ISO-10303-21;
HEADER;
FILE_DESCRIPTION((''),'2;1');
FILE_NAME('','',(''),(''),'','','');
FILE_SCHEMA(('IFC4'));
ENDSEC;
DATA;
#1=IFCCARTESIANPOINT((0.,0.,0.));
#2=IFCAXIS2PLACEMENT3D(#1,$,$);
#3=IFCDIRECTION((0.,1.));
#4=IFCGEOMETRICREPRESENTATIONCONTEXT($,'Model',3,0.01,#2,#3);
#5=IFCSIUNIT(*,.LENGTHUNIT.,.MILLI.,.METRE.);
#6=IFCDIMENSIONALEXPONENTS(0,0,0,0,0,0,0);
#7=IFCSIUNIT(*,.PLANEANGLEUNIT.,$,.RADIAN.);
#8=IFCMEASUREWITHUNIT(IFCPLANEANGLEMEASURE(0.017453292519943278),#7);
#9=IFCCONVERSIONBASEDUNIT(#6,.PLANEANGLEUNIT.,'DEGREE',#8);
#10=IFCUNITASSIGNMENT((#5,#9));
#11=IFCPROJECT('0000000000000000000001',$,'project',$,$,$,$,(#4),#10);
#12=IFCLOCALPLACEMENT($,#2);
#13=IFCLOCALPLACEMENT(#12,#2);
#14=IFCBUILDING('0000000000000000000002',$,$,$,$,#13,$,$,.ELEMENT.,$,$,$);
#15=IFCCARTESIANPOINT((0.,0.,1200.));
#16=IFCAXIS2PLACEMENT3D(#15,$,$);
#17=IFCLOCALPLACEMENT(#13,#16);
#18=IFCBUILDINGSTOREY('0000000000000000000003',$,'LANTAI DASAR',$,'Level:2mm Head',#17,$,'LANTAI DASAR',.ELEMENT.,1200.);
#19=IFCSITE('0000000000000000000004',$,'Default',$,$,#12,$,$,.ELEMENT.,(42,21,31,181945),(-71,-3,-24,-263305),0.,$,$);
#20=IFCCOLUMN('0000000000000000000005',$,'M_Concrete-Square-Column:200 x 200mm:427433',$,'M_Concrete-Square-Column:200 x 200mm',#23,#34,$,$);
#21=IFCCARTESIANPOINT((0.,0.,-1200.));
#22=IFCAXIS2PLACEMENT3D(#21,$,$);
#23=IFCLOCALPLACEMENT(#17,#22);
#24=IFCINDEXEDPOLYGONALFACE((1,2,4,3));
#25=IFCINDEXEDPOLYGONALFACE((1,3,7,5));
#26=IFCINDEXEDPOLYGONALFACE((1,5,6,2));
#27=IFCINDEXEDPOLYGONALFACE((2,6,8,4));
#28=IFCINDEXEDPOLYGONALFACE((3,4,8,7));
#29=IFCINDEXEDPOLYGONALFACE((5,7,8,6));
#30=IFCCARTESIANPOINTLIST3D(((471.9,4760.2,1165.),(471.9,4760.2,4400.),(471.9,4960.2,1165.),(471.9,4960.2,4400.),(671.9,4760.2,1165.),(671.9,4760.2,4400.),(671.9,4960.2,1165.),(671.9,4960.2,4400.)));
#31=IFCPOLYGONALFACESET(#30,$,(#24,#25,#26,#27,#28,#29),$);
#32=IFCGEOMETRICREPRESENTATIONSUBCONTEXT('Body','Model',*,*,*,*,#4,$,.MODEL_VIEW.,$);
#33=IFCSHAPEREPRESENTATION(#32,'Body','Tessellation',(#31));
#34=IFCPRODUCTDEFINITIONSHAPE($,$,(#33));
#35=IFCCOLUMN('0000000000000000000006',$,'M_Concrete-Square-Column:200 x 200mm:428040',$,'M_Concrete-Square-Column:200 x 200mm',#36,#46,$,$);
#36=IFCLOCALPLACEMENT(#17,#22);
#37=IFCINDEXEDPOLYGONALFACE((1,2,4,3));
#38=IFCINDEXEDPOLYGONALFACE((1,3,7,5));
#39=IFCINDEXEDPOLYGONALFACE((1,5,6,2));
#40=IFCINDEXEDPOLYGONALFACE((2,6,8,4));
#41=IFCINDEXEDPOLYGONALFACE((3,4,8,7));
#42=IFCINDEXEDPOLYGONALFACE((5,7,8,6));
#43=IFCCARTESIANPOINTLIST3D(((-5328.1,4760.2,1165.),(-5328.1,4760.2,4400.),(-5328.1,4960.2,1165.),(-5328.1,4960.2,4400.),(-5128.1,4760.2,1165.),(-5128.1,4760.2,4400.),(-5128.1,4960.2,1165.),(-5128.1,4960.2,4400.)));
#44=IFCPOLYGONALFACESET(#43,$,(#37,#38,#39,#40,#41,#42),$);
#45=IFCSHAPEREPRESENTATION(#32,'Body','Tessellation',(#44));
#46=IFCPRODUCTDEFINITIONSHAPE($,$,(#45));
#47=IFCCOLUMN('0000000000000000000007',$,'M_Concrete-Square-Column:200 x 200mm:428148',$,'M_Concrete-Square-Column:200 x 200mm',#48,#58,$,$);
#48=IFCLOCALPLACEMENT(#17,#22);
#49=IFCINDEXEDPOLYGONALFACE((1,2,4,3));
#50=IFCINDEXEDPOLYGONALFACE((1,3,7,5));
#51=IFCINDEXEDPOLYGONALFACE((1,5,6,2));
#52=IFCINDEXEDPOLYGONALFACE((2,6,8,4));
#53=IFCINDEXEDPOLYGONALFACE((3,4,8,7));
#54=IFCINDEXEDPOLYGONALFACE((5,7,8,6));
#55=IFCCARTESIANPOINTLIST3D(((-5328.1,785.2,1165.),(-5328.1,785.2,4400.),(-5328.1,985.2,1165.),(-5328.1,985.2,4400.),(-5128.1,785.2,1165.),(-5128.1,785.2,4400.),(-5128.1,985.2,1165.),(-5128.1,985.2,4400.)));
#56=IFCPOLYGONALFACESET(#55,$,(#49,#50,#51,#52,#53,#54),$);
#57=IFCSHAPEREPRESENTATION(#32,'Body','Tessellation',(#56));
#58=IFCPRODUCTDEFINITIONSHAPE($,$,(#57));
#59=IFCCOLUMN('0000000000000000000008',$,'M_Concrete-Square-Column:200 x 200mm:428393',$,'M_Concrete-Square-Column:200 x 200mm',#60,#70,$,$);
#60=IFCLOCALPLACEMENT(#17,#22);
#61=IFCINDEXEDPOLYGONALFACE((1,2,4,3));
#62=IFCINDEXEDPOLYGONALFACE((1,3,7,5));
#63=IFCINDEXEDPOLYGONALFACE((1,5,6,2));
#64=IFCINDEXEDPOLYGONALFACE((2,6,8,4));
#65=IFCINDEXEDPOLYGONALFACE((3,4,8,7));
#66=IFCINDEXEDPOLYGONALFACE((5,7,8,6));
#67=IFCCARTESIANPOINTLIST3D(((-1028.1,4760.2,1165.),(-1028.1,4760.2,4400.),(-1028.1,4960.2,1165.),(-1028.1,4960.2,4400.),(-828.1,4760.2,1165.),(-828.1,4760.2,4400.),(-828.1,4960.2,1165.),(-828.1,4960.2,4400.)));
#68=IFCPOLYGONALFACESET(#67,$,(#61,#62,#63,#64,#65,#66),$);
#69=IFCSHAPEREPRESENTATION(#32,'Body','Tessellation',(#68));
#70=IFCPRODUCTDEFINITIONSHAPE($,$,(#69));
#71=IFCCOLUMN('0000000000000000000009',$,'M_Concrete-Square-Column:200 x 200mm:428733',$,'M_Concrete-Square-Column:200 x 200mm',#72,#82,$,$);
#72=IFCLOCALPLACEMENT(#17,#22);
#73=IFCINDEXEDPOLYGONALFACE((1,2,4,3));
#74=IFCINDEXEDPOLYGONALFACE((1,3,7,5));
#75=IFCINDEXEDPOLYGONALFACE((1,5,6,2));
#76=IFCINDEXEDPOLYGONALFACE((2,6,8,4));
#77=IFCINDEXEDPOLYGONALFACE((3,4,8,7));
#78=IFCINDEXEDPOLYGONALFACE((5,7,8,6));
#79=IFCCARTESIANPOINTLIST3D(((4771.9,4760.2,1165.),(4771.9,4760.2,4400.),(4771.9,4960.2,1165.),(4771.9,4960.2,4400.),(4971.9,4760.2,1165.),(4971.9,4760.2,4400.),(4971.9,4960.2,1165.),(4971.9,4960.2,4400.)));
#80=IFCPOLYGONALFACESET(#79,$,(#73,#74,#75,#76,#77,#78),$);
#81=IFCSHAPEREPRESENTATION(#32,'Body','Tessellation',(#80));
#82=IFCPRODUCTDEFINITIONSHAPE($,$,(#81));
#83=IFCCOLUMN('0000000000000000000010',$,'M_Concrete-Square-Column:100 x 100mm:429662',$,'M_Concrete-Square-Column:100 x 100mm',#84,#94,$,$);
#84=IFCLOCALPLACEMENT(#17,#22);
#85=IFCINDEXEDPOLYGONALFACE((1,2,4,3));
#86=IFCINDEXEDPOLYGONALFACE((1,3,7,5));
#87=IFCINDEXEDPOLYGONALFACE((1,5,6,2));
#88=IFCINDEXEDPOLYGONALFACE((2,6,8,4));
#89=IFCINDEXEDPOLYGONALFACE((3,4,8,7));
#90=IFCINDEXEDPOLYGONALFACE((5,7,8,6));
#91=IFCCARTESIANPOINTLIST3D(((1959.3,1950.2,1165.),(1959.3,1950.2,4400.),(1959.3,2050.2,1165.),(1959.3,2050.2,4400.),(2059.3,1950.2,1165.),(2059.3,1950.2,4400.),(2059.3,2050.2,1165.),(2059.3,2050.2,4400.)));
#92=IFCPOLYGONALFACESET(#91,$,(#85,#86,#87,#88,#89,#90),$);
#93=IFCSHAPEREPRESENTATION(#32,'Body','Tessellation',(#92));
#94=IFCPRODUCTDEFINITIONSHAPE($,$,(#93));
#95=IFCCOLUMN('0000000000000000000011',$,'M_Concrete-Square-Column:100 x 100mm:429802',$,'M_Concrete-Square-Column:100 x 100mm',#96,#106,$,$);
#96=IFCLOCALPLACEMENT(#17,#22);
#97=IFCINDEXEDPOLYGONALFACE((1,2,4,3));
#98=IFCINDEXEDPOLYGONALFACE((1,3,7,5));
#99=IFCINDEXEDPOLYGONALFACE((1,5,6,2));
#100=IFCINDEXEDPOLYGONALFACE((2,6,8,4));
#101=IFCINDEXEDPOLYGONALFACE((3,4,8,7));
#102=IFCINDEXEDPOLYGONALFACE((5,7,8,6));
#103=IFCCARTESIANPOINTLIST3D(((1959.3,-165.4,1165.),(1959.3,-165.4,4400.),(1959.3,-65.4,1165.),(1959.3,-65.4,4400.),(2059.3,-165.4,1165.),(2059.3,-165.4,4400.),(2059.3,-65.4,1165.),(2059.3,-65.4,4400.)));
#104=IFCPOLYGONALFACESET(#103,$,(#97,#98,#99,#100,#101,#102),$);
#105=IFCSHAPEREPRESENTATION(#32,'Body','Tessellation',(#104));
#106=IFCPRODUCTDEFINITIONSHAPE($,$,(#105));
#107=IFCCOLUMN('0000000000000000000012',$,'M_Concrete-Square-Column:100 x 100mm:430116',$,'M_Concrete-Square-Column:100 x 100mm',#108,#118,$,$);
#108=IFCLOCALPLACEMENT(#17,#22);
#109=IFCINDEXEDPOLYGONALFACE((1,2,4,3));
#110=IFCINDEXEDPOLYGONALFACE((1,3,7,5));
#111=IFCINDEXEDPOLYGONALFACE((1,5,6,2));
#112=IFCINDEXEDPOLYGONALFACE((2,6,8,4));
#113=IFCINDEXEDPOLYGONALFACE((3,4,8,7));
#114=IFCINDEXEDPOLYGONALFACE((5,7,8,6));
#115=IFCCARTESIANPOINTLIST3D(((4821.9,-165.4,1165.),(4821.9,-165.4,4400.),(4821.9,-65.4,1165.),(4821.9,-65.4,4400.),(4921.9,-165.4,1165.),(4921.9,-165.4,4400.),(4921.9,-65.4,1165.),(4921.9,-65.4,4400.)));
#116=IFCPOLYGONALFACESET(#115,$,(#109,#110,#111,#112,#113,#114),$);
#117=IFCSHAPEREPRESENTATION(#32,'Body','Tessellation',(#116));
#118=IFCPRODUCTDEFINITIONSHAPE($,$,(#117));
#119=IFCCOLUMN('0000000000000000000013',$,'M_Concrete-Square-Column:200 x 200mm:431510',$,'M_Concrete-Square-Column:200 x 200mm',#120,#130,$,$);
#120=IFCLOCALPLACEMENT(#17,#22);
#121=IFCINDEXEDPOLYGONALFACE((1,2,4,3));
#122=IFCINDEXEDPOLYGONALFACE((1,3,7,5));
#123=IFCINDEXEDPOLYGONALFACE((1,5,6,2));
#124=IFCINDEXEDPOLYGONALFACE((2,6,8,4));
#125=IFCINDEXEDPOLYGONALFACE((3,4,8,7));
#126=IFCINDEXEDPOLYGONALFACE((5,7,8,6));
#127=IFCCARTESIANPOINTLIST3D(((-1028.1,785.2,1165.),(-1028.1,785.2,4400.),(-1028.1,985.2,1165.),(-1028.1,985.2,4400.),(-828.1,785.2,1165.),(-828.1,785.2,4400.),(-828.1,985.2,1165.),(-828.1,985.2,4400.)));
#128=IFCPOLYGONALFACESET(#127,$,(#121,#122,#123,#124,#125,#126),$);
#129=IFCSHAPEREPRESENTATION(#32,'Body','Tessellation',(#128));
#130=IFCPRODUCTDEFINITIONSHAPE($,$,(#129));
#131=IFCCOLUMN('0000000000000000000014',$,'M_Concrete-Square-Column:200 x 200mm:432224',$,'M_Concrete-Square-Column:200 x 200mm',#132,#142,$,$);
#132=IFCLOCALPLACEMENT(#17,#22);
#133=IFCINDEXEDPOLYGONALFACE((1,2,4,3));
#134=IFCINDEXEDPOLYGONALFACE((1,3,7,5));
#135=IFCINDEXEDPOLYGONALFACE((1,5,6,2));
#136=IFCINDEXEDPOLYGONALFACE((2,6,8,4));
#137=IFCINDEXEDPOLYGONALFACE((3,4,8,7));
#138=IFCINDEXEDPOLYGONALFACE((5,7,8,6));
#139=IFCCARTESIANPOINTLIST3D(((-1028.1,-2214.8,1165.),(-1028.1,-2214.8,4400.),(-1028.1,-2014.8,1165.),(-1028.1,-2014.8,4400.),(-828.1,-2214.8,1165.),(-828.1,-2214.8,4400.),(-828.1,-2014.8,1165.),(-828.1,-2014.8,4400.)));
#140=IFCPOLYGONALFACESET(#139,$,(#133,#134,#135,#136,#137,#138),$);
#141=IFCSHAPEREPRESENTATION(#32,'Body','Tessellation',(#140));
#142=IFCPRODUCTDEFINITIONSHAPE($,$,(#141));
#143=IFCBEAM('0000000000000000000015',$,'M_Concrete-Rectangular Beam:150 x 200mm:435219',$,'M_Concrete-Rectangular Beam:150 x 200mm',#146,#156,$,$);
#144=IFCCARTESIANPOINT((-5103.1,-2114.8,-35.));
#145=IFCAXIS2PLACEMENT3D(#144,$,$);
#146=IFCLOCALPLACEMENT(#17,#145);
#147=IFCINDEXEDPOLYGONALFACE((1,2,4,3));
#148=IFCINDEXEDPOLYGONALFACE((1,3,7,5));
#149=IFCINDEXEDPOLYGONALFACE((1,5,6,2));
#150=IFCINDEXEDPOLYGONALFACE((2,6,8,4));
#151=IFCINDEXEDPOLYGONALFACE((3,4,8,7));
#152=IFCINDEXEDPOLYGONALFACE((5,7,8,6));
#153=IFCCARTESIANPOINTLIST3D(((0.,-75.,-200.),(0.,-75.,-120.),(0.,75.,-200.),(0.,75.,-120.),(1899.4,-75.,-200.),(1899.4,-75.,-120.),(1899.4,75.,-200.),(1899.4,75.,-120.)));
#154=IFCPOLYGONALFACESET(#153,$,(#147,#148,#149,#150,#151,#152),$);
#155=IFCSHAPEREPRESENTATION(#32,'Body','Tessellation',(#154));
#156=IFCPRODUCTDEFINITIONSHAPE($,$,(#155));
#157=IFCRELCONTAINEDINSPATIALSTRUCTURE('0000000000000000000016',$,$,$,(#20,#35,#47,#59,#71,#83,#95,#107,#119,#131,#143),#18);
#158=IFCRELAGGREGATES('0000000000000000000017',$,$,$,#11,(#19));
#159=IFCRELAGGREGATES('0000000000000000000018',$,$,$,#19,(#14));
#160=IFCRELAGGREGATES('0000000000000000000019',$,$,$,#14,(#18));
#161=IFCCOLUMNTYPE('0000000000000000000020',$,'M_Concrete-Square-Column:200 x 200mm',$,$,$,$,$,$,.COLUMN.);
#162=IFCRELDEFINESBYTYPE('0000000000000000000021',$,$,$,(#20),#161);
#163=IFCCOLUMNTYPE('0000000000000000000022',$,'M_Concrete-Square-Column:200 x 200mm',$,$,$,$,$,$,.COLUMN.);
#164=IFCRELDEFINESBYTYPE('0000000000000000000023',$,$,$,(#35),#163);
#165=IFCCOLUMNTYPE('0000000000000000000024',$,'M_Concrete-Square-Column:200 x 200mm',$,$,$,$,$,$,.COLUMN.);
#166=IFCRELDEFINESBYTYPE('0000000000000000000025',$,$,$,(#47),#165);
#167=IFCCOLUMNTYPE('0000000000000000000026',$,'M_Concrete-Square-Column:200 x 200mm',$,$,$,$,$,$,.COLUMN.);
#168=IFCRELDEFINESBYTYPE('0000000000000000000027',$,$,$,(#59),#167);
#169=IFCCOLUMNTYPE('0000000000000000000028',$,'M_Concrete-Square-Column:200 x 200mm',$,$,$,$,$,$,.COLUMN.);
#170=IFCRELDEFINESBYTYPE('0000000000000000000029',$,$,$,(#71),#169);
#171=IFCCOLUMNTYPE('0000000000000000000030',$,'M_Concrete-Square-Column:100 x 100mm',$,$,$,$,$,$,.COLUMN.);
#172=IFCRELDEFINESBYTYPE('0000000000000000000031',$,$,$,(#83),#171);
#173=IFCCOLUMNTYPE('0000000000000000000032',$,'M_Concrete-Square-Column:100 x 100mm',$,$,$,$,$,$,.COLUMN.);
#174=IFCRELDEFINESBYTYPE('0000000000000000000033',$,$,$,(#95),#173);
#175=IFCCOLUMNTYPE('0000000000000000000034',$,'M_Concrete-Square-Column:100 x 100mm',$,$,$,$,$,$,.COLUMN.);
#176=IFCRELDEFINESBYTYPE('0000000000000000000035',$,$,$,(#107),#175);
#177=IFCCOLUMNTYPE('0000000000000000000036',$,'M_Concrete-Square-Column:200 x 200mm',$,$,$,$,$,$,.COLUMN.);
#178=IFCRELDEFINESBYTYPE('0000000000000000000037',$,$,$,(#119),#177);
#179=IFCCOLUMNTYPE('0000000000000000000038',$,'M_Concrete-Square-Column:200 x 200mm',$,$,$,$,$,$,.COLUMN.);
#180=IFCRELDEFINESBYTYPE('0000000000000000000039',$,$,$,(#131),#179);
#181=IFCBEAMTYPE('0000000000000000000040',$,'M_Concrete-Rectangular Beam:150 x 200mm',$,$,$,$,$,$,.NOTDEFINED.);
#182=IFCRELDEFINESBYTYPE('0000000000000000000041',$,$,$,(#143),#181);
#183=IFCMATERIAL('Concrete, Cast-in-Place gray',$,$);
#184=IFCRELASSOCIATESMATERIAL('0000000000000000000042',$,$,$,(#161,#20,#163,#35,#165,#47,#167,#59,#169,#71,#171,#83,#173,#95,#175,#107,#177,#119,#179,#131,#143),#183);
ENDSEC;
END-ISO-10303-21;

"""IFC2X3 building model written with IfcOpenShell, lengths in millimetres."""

from ifc_helpers import new_model, entity, si_unit, converted_unit, direction, frame, frame_2d, origin, origin_2d_with_axis, place, context, subcontext, project, spatial, rectangle, extrude, source, transform, mapped, material, type_object, type_shapes, element, save


model = new_model("IFC2X3")

# Units and contexts
model_context = context("Model", 3, precision=0.01, world=origin(), true_north=direction((0.0, 1.0)))
body_context = subcontext(model_context, "Body", "Model", "MODEL_VIEW")
ifc_project = project(units=[si_unit("LENGTHUNIT", "METRE", prefix="MILLI"), converted_unit("PLANEANGLEUNIT", "DEGREE", entity("IfcPlaneAngleMeasure", 0.017453292519943278), si_unit("PLANEANGLEUNIT", "RADIAN"), dimensions=[0, 0, 0, 0, 0, 0, 0])], contexts=[model_context])

# Site, building, storey
site_placement = place(None, origin())
site = spatial("IfcSite", under=ifc_project, at=site_placement, Name="Default", CompositionType="ELEMENT", RefLatitude=(42, 21, 31, 181945), RefLongitude=(-71, -3, -24, -263305), RefElevation=0.0)
building_placement = place(site_placement, origin())
building = spatial("IfcBuilding", under=site, at=building_placement, CompositionType="ELEMENT")
storey_placement = place(building_placement, frame((0.0, 0.0, 1200.0)))
storey = spatial("IfcBuildingStorey", under=building, at=storey_placement, Name="LANTAI DASAR", ObjectType="Level:2mm Head", LongName="LANTAI DASAR", CompositionType="ELEMENT", Elevation=1200.0)

# Columns
ifc_material = material(Name="Concrete, Cast-in-Place gray")
column_type_1 = type_object("IfcColumnType", Name="M_Concrete-Square-Column:200 x 200mm", PredefinedType="COLUMN", material=ifc_material)
shared_shape_1 = source(origin(), body_context, "Body", "SweptSolid", [
    extrude(rectangle(XDim=200.0, YDim=200.0, at=origin_2d_with_axis()), frame((571.9, 4860.2, 1165.0), z_axis=(0.0, 0.0, 1.0), x_axis=(-1.0, 0.0, 0.0)), (0.0, 0.0, 1.0), 3235.0),
])
type_shapes(column_type_1, [shared_shape_1])
column_1_placement = place(storey_placement, frame((0.0, 0.0, -1200.0)))
element("IfcColumn", 1, at=column_1_placement, inside=storey, type_object=column_type_1, material=ifc_material, Name="M_Concrete-Square-Column:200 x 200mm:427433", ObjectType="M_Concrete-Square-Column:200 x 200mm", context=body_context, shape_type="MappedRepresentation", body=[
    mapped(shared_shape_1, transform((0.0, 0.0, 0.0), scale=1.0)),
])
column_type_2 = type_object("IfcColumnType", Name="M_Concrete-Square-Column:200 x 200mm", PredefinedType="COLUMN", material=ifc_material)
shared_shape_2 = source(origin(), body_context, "Body", "SweptSolid", [
    extrude(rectangle(XDim=200.0, YDim=200.0, at=origin_2d_with_axis()), frame((-5228.1, 4860.2, 1165.0), z_axis=(0.0, 0.0, 1.0), x_axis=(-1.0, 0.0, 0.0)), (0.0, 0.0, 1.0), 3235.0),
])
type_shapes(column_type_2, [shared_shape_2])
column_2_placement = place(storey_placement, frame((0.0, 0.0, -1200.0)))
element("IfcColumn", 2, at=column_2_placement, inside=storey, type_object=column_type_2, material=ifc_material, Name="M_Concrete-Square-Column:200 x 200mm:428040", ObjectType="M_Concrete-Square-Column:200 x 200mm", context=body_context, shape_type="MappedRepresentation", body=[
    mapped(shared_shape_2, transform((0.0, 0.0, 0.0), scale=1.0)),
])
column_type_3 = type_object("IfcColumnType", Name="M_Concrete-Square-Column:200 x 200mm", PredefinedType="COLUMN", material=ifc_material)
shared_shape_3 = source(origin(), body_context, "Body", "SweptSolid", [
    extrude(rectangle(XDim=200.0, YDim=200.0, at=origin_2d_with_axis()), frame((-5228.1, 885.2, 1165.0), z_axis=(0.0, 0.0, 1.0), x_axis=(-1.0, 0.0, 0.0)), (0.0, 0.0, 1.0), 3235.0),
])
type_shapes(column_type_3, [shared_shape_3])
column_3_placement = place(storey_placement, frame((0.0, 0.0, -1200.0)))
element("IfcColumn", 3, at=column_3_placement, inside=storey, type_object=column_type_3, material=ifc_material, Name="M_Concrete-Square-Column:200 x 200mm:428148", ObjectType="M_Concrete-Square-Column:200 x 200mm", context=body_context, shape_type="MappedRepresentation", body=[
    mapped(shared_shape_3, transform((0.0, 0.0, 0.0), scale=1.0)),
])
column_type_4 = type_object("IfcColumnType", Name="M_Concrete-Square-Column:200 x 200mm", PredefinedType="COLUMN", material=ifc_material)
shared_shape_4 = source(origin(), body_context, "Body", "SweptSolid", [
    extrude(rectangle(XDim=200.0, YDim=200.0, at=origin_2d_with_axis()), frame((-928.1, 4860.2, 1165.0), z_axis=(0.0, 0.0, 1.0), x_axis=(-1.0, 0.0, 0.0)), (0.0, 0.0, 1.0), 3235.0),
])
type_shapes(column_type_4, [shared_shape_4])
column_4_placement = place(storey_placement, frame((0.0, 0.0, -1200.0)))
element("IfcColumn", 4, at=column_4_placement, inside=storey, type_object=column_type_4, material=ifc_material, Name="M_Concrete-Square-Column:200 x 200mm:428393", ObjectType="M_Concrete-Square-Column:200 x 200mm", context=body_context, shape_type="MappedRepresentation", body=[
    mapped(shared_shape_4, transform((0.0, 0.0, 0.0), scale=1.0)),
])
column_type_5 = type_object("IfcColumnType", Name="M_Concrete-Square-Column:200 x 200mm", PredefinedType="COLUMN", material=ifc_material)
shared_shape_5 = source(origin(), body_context, "Body", "SweptSolid", [
    extrude(rectangle(XDim=200.0, YDim=200.0, at=origin_2d_with_axis()), frame((4871.9, 4860.2, 1165.0), z_axis=(0.0, 0.0, 1.0), x_axis=(-1.0, 0.0, 0.0)), (0.0, 0.0, 1.0), 3235.0),
])
type_shapes(column_type_5, [shared_shape_5])
column_5_placement = place(storey_placement, frame((0.0, 0.0, -1200.0)))
element("IfcColumn", 5, at=column_5_placement, inside=storey, type_object=column_type_5, material=ifc_material, Name="M_Concrete-Square-Column:200 x 200mm:428733", ObjectType="M_Concrete-Square-Column:200 x 200mm", context=body_context, shape_type="MappedRepresentation", body=[
    mapped(shared_shape_5, transform((0.0, 0.0, 0.0), scale=1.0)),
])
column_type_6 = type_object("IfcColumnType", Name="M_Concrete-Square-Column:100 x 100mm", PredefinedType="COLUMN", material=ifc_material)
shared_shape_6 = source(origin(), body_context, "Body", "SweptSolid", [
    extrude(rectangle(XDim=100.0, YDim=100.0, at=origin_2d_with_axis()), frame((2009.3, 2000.2, 1165.0), z_axis=(0.0, 0.0, 1.0), x_axis=(-1.0, 0.0, 0.0)), (0.0, 0.0, 1.0), 3235.0),
])
type_shapes(column_type_6, [shared_shape_6])
column_6_placement = place(storey_placement, frame((0.0, 0.0, -1200.0)))
element("IfcColumn", 6, at=column_6_placement, inside=storey, type_object=column_type_6, material=ifc_material, Name="M_Concrete-Square-Column:100 x 100mm:429662", ObjectType="M_Concrete-Square-Column:100 x 100mm", context=body_context, shape_type="MappedRepresentation", body=[
    mapped(shared_shape_6, transform((0.0, 0.0, 0.0), scale=1.0)),
])
column_type_7 = type_object("IfcColumnType", Name="M_Concrete-Square-Column:100 x 100mm", PredefinedType="COLUMN", material=ifc_material)
shared_shape_7 = source(origin(), body_context, "Body", "SweptSolid", [
    extrude(rectangle(XDim=100.0, YDim=100.0, at=origin_2d_with_axis()), frame((2009.3, -115.4, 1165.0), z_axis=(0.0, 0.0, 1.0), x_axis=(-1.0, 0.0, 0.0)), (0.0, 0.0, 1.0), 3235.0),
])
type_shapes(column_type_7, [shared_shape_7])
column_7_placement = place(storey_placement, frame((0.0, 0.0, -1200.0)))
element("IfcColumn", 7, at=column_7_placement, inside=storey, type_object=column_type_7, material=ifc_material, Name="M_Concrete-Square-Column:100 x 100mm:429802", ObjectType="M_Concrete-Square-Column:100 x 100mm", context=body_context, shape_type="MappedRepresentation", body=[
    mapped(shared_shape_7, transform((0.0, 0.0, 0.0), scale=1.0)),
])
column_type_8 = type_object("IfcColumnType", Name="M_Concrete-Square-Column:100 x 100mm", PredefinedType="COLUMN", material=ifc_material)
shared_shape_8 = source(origin(), body_context, "Body", "SweptSolid", [
    extrude(rectangle(XDim=100.0, YDim=100.0, at=frame_2d((0.0, 0.0), x_axis=(1.0, 0.0))), frame((4871.9, -115.4, 1165.0), z_axis=(0.0, 0.0, 1.0), x_axis=(-1.0, 0.0, 0.0)), (0.0, 0.0, 1.0), 3235.0),
])
type_shapes(column_type_8, [shared_shape_8])
column_8_placement = place(storey_placement, frame((0.0, 0.0, -1200.0)))
element("IfcColumn", 8, at=column_8_placement, inside=storey, type_object=column_type_8, material=ifc_material, Name="M_Concrete-Square-Column:100 x 100mm:430116", ObjectType="M_Concrete-Square-Column:100 x 100mm", context=body_context, shape_type="MappedRepresentation", body=[
    mapped(shared_shape_8, transform((0.0, 0.0, 0.0), scale=1.0)),
])
column_type_9 = type_object("IfcColumnType", Name="M_Concrete-Square-Column:200 x 200mm", PredefinedType="COLUMN", material=ifc_material)
shared_shape_9 = source(origin(), body_context, "Body", "SweptSolid", [
    extrude(rectangle(XDim=200.0, YDim=200.0, at=origin_2d_with_axis()), frame((-928.1, 885.2, 1165.0), z_axis=(0.0, 0.0, 1.0), x_axis=(-1.0, 0.0, 0.0)), (0.0, 0.0, 1.0), 3235.0),
])
type_shapes(column_type_9, [shared_shape_9])
column_9_placement = place(storey_placement, frame((0.0, 0.0, -1200.0)))
element("IfcColumn", 9, at=column_9_placement, inside=storey, type_object=column_type_9, material=ifc_material, Name="M_Concrete-Square-Column:200 x 200mm:431510", ObjectType="M_Concrete-Square-Column:200 x 200mm", context=body_context, shape_type="MappedRepresentation", body=[
    mapped(shared_shape_9, transform((0.0, 0.0, 0.0), scale=1.0)),
])
column_type_10 = type_object("IfcColumnType", Name="M_Concrete-Square-Column:200 x 200mm", PredefinedType="COLUMN", material=ifc_material)
shared_shape_10 = source(origin(), body_context, "Body", "SweptSolid", [
    extrude(rectangle(XDim=200.0, YDim=200.0, at=origin_2d_with_axis()), frame((-928.1, -2114.8, 1165.0), z_axis=(0.0, 0.0, 1.0), x_axis=(-1.0, 0.0, 0.0)), (0.0, 0.0, 1.0), 3235.0),
])
type_shapes(column_type_10, [shared_shape_10])
column_10_placement = place(storey_placement, frame((0.0, 0.0, -1200.0)))
element("IfcColumn", 10, at=column_10_placement, inside=storey, type_object=column_type_10, material=ifc_material, Name="M_Concrete-Square-Column:200 x 200mm:432224", ObjectType="M_Concrete-Square-Column:200 x 200mm", context=body_context, shape_type="MappedRepresentation", body=[
    mapped(shared_shape_10, transform((0.0, 0.0, 0.0), scale=1.0)),
])

# Beam
beam_type = type_object("IfcBeamType", Name="M_Concrete-Rectangular Beam:150 x 200mm", PredefinedType="NOTDEFINED")
beam_1_placement = place(storey_placement, frame((-5103.1, -2114.8, -35.0)))
element("IfcBeam", 11, at=beam_1_placement, inside=storey, type_object=beam_type, material=ifc_material, Name="M_Concrete-Rectangular Beam:150 x 200mm:435219", ObjectType="M_Concrete-Rectangular Beam:150 x 200mm", context=body_context, shape_type="SweptSolid", body=[
    extrude(rectangle(XDim=80.0, YDim=150.0, at=frame_2d((0.0, 0.0), x_axis=(1.0, 0.0))), frame((0.0, 0.0, -160.0), z_axis=(1.0, 0.0, 0.0), x_axis=(0.0, 0.0, -1.0)), (0.0, 0.0, 1.0), 1899.4),
])

save(model, "model.ifc")
